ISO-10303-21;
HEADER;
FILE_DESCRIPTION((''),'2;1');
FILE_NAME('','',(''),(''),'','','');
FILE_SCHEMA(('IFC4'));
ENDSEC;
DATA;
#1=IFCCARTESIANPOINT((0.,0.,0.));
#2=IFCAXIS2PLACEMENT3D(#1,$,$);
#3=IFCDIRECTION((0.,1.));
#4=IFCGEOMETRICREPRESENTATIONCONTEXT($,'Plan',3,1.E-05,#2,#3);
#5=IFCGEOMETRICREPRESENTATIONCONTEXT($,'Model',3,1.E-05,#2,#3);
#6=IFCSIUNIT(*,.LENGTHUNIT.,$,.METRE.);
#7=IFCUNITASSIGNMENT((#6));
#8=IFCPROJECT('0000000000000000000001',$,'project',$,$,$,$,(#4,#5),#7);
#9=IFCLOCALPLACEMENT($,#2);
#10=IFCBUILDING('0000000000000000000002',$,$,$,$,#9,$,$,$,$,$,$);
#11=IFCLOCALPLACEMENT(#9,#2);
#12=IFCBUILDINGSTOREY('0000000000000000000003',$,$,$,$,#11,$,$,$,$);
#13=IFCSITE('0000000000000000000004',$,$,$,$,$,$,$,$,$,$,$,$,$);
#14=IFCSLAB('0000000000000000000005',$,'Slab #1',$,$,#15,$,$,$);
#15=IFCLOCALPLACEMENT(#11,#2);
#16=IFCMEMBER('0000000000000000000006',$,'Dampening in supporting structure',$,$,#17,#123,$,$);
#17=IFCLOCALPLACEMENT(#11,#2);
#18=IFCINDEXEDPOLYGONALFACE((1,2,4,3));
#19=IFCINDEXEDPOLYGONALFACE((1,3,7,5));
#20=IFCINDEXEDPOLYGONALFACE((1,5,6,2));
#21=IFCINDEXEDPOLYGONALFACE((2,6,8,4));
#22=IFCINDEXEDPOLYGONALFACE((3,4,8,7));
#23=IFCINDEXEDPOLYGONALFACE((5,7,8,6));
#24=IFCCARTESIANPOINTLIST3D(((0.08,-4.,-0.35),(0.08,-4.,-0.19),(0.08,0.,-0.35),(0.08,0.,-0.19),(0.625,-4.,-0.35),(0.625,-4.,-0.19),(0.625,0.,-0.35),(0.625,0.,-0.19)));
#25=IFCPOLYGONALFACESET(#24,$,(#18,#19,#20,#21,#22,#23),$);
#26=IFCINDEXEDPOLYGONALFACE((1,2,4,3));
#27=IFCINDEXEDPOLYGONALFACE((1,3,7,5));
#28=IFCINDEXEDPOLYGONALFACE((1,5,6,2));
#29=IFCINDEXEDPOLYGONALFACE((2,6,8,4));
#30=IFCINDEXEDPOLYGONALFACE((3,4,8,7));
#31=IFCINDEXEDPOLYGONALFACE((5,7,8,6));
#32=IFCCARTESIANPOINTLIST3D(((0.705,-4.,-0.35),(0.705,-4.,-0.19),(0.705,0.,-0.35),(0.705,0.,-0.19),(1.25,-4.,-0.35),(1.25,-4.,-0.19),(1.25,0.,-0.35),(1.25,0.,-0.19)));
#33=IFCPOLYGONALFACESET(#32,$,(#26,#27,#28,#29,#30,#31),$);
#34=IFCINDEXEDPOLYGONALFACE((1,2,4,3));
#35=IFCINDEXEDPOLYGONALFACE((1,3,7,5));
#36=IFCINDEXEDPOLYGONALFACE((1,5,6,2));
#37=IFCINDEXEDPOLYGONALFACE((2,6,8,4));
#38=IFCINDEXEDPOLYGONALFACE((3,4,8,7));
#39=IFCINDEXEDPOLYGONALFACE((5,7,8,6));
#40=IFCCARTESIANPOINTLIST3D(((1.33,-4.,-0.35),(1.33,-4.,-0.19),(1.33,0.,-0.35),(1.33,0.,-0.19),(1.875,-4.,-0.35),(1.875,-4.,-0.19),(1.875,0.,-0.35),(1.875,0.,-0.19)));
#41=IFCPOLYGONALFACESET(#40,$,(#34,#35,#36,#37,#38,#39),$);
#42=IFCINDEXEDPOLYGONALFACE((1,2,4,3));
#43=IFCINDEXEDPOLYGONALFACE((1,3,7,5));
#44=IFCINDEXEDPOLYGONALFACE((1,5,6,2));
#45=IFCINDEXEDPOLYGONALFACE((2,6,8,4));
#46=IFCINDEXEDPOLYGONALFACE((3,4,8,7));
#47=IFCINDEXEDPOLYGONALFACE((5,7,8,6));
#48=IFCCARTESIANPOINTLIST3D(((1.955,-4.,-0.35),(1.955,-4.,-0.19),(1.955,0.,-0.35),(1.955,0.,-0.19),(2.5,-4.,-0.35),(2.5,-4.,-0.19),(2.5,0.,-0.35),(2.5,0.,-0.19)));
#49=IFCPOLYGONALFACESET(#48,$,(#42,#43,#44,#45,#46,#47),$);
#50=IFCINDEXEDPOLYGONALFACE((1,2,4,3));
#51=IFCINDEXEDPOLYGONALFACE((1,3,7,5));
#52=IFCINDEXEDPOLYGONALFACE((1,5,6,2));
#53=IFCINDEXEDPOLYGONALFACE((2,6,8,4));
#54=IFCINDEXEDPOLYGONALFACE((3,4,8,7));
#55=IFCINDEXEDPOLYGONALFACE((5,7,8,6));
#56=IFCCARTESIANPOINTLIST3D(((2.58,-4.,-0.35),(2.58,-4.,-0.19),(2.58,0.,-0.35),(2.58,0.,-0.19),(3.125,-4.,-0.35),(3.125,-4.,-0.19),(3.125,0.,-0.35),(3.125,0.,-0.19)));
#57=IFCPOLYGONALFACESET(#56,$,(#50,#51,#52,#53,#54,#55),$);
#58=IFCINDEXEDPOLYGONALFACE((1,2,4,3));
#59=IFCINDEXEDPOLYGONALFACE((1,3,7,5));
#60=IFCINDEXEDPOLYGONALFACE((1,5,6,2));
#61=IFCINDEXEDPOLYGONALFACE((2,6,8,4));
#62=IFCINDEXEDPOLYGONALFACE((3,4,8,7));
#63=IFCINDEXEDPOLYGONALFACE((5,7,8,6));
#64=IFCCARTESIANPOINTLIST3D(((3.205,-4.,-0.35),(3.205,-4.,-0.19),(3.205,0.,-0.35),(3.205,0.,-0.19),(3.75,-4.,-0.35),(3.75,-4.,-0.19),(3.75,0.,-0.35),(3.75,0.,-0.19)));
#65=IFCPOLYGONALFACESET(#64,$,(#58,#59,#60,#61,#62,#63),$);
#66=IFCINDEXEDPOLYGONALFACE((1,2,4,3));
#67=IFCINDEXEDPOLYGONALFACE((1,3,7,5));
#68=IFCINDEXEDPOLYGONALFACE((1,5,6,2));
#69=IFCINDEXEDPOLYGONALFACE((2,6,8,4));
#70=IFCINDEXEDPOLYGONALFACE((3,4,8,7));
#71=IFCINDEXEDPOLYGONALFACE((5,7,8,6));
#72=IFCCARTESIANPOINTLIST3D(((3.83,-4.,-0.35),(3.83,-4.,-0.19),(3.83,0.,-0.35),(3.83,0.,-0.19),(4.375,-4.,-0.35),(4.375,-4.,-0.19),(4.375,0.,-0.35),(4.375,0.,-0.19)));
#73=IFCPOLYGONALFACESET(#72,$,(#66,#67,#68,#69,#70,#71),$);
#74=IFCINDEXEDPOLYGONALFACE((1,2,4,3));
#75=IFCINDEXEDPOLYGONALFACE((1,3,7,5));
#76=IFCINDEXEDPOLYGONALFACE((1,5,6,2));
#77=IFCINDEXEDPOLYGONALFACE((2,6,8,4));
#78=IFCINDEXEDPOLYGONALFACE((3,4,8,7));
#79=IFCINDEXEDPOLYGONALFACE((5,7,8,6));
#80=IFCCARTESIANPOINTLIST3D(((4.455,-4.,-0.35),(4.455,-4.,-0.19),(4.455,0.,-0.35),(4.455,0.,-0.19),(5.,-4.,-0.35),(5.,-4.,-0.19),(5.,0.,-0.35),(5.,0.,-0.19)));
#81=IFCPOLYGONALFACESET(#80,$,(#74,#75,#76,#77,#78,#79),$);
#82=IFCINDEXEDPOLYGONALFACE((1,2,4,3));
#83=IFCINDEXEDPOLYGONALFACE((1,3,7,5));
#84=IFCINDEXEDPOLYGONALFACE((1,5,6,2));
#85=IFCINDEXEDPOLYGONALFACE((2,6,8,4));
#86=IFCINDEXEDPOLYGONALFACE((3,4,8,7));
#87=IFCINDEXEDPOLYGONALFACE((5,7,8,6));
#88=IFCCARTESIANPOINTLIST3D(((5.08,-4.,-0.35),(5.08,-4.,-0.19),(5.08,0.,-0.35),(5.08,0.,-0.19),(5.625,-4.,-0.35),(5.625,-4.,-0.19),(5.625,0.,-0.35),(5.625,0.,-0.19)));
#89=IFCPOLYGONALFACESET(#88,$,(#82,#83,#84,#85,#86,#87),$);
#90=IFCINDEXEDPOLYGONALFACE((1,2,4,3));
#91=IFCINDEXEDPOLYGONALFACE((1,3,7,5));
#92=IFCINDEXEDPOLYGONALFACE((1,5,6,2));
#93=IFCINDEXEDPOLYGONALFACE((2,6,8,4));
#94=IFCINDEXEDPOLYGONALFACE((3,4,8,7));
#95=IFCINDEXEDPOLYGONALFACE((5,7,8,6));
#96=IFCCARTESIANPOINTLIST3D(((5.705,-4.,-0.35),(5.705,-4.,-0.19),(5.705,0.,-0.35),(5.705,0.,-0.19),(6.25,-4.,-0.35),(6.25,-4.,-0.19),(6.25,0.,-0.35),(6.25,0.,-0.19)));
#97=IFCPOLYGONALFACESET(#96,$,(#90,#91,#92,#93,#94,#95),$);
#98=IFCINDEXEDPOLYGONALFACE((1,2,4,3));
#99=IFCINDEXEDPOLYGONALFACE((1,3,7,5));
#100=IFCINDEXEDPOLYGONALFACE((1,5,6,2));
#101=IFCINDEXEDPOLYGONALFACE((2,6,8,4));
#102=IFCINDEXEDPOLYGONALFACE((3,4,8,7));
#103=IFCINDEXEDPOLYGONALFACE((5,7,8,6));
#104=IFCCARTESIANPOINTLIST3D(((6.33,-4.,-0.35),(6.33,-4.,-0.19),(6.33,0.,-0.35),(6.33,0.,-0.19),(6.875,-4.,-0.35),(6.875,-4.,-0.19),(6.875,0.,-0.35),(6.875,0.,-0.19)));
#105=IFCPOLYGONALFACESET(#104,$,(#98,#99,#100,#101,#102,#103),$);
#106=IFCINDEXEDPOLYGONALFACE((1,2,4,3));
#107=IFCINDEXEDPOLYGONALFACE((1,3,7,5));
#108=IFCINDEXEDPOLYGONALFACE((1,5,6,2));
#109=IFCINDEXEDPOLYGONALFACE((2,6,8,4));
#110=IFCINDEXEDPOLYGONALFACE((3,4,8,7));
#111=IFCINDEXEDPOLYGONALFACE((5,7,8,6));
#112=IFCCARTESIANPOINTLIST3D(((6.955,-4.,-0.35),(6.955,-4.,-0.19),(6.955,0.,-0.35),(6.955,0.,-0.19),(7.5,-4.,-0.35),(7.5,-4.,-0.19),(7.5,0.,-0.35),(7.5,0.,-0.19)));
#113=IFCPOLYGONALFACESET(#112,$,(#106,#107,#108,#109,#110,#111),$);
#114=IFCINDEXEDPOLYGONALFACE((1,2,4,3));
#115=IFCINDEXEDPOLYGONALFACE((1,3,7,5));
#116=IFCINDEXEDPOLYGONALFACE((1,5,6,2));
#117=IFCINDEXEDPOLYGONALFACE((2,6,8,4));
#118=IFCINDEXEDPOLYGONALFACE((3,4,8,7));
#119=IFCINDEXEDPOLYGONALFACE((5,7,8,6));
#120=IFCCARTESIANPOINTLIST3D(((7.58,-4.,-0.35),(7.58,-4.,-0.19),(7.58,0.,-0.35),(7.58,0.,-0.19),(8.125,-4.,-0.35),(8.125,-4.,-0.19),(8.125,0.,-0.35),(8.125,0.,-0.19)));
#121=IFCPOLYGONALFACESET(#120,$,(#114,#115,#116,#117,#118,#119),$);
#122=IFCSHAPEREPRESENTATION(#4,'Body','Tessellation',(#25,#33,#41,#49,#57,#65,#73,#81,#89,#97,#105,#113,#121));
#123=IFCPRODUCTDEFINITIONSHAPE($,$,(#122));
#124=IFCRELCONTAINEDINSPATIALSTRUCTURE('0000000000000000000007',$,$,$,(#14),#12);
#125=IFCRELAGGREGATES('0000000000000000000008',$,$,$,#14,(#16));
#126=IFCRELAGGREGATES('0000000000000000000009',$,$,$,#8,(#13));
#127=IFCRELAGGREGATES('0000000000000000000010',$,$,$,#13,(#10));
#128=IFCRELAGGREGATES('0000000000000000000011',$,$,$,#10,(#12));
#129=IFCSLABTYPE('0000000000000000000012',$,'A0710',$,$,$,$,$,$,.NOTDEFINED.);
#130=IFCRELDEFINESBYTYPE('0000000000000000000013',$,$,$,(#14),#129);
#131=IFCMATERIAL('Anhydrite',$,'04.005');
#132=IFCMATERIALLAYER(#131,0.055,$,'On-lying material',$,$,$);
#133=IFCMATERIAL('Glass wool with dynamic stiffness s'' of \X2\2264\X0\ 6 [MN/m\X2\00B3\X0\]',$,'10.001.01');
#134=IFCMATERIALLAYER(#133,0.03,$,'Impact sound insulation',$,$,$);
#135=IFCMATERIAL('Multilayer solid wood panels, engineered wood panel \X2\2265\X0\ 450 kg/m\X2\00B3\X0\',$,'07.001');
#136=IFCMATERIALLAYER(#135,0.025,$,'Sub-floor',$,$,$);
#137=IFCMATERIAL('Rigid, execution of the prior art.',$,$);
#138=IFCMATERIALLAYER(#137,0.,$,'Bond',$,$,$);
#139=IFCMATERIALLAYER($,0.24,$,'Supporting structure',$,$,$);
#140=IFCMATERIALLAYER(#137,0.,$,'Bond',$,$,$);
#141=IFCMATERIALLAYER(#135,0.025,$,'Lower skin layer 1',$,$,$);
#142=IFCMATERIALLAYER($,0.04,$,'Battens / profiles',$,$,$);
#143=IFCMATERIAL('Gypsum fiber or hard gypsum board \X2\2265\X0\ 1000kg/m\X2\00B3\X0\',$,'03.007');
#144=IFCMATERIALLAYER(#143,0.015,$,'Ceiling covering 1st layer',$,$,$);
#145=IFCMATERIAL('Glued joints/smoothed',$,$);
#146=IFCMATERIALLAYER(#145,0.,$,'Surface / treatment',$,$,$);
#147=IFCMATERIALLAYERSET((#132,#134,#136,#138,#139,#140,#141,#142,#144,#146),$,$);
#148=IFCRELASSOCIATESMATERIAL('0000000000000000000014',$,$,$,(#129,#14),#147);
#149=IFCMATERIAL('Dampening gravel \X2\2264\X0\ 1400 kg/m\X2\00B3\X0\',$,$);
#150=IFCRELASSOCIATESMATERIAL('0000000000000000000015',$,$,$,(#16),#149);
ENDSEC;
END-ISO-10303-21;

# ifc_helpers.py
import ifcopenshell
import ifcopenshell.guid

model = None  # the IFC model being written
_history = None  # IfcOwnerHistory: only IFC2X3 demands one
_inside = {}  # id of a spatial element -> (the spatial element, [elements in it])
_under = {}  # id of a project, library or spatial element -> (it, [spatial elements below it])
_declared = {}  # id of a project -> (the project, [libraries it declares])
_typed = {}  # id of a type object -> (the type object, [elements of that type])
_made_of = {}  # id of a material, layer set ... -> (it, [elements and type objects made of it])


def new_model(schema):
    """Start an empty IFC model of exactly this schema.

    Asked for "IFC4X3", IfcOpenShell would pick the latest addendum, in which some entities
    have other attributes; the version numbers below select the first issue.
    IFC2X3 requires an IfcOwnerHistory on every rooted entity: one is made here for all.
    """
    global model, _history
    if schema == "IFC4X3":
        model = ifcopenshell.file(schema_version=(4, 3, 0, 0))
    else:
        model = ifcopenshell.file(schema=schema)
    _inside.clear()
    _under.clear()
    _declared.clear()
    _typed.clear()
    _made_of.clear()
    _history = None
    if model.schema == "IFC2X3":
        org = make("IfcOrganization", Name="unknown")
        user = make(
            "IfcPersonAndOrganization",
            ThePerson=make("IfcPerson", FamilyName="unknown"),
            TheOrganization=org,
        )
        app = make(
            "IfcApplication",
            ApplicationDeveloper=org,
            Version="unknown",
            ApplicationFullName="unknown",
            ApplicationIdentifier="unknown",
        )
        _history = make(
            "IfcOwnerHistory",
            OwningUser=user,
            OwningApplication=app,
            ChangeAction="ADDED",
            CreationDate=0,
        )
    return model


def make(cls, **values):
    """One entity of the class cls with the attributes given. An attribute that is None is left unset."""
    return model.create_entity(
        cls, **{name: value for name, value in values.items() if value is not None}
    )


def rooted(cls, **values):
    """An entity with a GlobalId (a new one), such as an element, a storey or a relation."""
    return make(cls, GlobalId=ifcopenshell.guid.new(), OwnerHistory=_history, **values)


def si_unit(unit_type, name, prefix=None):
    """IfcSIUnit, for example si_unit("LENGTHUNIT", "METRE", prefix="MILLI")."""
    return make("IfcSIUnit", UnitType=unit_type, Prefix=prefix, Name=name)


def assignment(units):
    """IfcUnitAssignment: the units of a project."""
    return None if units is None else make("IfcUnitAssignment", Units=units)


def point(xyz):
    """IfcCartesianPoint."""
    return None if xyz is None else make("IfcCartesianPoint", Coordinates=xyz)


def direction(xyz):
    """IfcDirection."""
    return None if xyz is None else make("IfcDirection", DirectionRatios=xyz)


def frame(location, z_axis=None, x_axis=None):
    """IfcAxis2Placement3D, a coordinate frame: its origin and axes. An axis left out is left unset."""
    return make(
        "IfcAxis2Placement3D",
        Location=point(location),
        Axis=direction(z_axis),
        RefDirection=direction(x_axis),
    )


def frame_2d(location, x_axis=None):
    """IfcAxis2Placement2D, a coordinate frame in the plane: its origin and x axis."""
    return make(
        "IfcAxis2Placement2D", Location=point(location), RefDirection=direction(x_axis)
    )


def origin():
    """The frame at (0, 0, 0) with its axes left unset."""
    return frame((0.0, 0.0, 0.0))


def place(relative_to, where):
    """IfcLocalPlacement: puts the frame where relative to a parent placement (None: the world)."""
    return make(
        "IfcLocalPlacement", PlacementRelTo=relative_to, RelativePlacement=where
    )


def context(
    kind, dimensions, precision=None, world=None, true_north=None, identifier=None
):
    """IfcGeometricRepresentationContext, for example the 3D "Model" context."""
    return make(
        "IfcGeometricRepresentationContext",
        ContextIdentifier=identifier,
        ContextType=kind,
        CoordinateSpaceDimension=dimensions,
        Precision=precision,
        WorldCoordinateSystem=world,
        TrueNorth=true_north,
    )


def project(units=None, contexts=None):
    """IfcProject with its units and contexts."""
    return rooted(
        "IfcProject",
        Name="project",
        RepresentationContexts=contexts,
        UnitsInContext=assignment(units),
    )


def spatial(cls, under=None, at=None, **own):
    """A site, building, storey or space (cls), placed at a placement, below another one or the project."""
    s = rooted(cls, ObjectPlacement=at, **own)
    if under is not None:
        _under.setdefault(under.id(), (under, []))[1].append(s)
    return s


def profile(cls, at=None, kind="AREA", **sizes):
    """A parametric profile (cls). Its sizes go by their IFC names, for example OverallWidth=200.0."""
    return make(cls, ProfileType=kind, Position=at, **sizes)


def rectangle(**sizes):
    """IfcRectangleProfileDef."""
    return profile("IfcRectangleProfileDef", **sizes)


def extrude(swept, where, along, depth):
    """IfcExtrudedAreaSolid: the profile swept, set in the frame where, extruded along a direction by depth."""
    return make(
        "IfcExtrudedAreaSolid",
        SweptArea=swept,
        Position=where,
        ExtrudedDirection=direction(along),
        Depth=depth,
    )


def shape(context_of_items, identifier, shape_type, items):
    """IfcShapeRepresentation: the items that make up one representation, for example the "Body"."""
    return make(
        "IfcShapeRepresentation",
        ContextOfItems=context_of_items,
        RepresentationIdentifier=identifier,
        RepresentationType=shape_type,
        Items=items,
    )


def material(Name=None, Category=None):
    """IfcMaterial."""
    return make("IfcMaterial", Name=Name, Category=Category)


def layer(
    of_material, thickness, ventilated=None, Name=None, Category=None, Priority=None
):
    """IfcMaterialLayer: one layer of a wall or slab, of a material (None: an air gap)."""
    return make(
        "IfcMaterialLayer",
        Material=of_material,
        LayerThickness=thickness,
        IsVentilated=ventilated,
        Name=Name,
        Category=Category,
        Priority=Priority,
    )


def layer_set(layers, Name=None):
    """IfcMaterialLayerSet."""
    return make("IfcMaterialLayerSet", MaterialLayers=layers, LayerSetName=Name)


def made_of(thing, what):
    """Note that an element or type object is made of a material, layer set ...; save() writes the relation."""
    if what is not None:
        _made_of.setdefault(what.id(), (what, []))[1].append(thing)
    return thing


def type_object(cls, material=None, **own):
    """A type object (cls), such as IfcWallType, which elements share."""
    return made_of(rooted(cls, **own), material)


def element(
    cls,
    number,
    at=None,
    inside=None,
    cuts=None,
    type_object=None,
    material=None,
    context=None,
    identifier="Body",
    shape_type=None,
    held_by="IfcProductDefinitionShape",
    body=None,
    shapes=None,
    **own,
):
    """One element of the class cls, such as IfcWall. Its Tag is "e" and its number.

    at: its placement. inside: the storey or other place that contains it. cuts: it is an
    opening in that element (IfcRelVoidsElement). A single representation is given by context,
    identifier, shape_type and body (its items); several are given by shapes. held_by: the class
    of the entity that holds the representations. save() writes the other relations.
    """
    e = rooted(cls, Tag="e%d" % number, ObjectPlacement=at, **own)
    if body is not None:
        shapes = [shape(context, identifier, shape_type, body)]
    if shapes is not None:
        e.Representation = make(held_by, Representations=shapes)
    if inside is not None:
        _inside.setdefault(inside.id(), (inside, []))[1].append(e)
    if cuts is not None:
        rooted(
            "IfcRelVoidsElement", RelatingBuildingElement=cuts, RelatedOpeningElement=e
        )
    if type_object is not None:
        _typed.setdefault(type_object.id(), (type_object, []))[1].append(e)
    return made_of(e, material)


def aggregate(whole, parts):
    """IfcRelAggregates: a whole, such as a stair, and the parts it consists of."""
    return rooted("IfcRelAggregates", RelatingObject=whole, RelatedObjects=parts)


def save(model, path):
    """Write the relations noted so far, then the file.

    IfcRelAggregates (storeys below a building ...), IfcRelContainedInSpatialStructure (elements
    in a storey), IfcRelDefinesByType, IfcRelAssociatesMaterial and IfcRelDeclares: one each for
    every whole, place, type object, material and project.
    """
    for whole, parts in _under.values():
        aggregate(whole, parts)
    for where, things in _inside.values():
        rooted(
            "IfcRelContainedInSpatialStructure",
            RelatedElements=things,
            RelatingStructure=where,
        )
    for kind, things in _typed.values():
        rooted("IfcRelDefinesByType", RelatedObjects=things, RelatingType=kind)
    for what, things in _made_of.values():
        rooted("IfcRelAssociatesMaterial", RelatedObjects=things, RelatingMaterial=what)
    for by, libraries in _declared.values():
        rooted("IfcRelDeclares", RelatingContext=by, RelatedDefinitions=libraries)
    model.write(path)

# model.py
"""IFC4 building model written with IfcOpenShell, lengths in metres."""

from ifc_helpers import new_model, si_unit, direction, frame, frame_2d, origin, place, context, project, spatial, rectangle, extrude, material, layer, layer_set, type_object, element, aggregate, save


model = new_model("IFC4")

# Units and contexts
plan_context = context("Plan", 3, precision=1e-05, world=origin(), true_north=direction((0.0, 1.0)))
model_context = context("Model", 3, precision=1e-05, world=origin(), true_north=direction((0.0, 1.0)))
ifc_project = project(units=[si_unit("LENGTHUNIT", "METRE")], contexts=[plan_context, model_context])

# Site, building, storey
site = spatial("IfcSite", under=ifc_project)
building_placement = place(None, origin())
building = spatial("IfcBuilding", under=site, at=building_placement)
storey_placement = place(building_placement, origin())
storey = spatial("IfcBuildingStorey", under=building, at=storey_placement)

# Slab, member
ifc_material_1 = material(Name="Anhydrite", Category="04.005")
ifc_layer_1 = layer(ifc_material_1, 0.055, Name="On-lying material")
ifc_material_2 = material(Name="Glass wool with dynamic stiffness s' of ≤ 6 [MN/m³]", Category="10.001.01")
ifc_layer_2 = layer(ifc_material_2, 0.03, Name="Impact sound insulation")
ifc_material_3 = material(Name="Multilayer solid wood panels, engineered wood panel ≥ 450 kg/m³", Category="07.001")
ifc_layer_3 = layer(ifc_material_3, 0.025, Name="Sub-floor")
ifc_material_4 = material(Name="Rigid, execution of the prior art.")
ifc_layer_4 = layer(ifc_material_4, 0.0, Name="Bond")
ifc_layer_5 = layer(None, 0.24, Name="Supporting structure")
ifc_layer_6 = layer(ifc_material_4, 0.0, Name="Bond")
ifc_layer_7 = layer(ifc_material_3, 0.025, Name="Lower skin layer 1")
ifc_layer_8 = layer(None, 0.04, Name="Battens / profiles")
ifc_material_5 = material(Name="Gypsum fiber or hard gypsum board ≥ 1000kg/m³", Category="03.007")
ifc_layer_9 = layer(ifc_material_5, 0.015, Name="Ceiling covering 1st layer")
ifc_material_6 = material(Name="Glued joints/smoothed")
ifc_layer_10 = layer(ifc_material_6, 0.0, Name="Surface / treatment")
ifc_layer_set = layer_set([ifc_layer_1, ifc_layer_2, ifc_layer_3, ifc_layer_4, ifc_layer_5, ifc_layer_6, ifc_layer_7, ifc_layer_8, ifc_layer_9, ifc_layer_10])
slab_type = type_object("IfcSlabType", Name="A0710", PredefinedType="NOTDEFINED", material=ifc_layer_set)
slab_placement = place(None, frame((0.0, 0.0, 0.0), z_axis=(0.0, 0.0, -1.0), x_axis=(1.0, 0.0, 0.0)))
slab = element("IfcSlab", 1, at=slab_placement, inside=storey, type_object=slab_type, material=ifc_layer_set, Name="Slab #1")
ifc_material_7 = material(Name="Dampening gravel ≤ 1400 kg/m³")
member_1_placement = place(slab_placement, origin())
member_1 = element("IfcMember", 2, at=member_1_placement, material=ifc_material_7, Name="Dampening in supporting structure", context=plan_context, shape_type="SweptSolid", body=[
    extrude(rectangle(XDim=0.545, YDim=0.16, at=frame_2d((0.2725, 0.08), x_axis=(1.0, 0.0))), frame((0.08, 4.0, 0.19), z_axis=(0.0, -1.0, 0.0), x_axis=(1.0, 0.0, 0.0)), (0.0, 0.0, 1.0), 4.0),
    extrude(rectangle(XDim=0.545, YDim=0.16, at=frame_2d((0.2725, 0.08), x_axis=(1.0, 0.0))), frame((0.705, 4.0, 0.19), z_axis=(0.0, -1.0, 0.0), x_axis=(1.0, 0.0, 0.0)), (0.0, 0.0, 1.0), 4.0),
    extrude(rectangle(XDim=0.545, YDim=0.16, at=frame_2d((0.2725, 0.08), x_axis=(1.0, 0.0))), frame((1.33, 4.0, 0.19), z_axis=(0.0, -1.0, 0.0), x_axis=(1.0, 0.0, 0.0)), (0.0, 0.0, 1.0), 4.0),
    extrude(rectangle(XDim=0.545, YDim=0.16, at=frame_2d((0.2725, 0.08), x_axis=(1.0, 0.0))), frame((1.955, 4.0, 0.19), z_axis=(0.0, -1.0, 0.0), x_axis=(1.0, 0.0, 0.0)), (0.0, 0.0, 1.0), 4.0),
    extrude(rectangle(XDim=0.545, YDim=0.16, at=frame_2d((0.2725, 0.08), x_axis=(1.0, 0.0))), frame((2.58, 4.0, 0.19), z_axis=(0.0, -1.0, 0.0), x_axis=(1.0, 0.0, 0.0)), (0.0, 0.0, 1.0), 4.0),
    extrude(rectangle(XDim=0.545, YDim=0.16, at=frame_2d((0.2725, 0.08), x_axis=(1.0, 0.0))), frame((3.205, 4.0, 0.19), z_axis=(0.0, -1.0, 0.0), x_axis=(1.0, 0.0, 0.0)), (0.0, 0.0, 1.0), 4.0),
    extrude(rectangle(XDim=0.545, YDim=0.16, at=frame_2d((0.2725, 0.08), x_axis=(1.0, 0.0))), frame((3.83, 4.0, 0.19), z_axis=(0.0, -1.0, 0.0), x_axis=(1.0, 0.0, 0.0)), (0.0, 0.0, 1.0), 4.0),
    extrude(rectangle(XDim=0.545, YDim=0.16, at=frame_2d((0.2725, 0.08), x_axis=(1.0, 0.0))), frame((4.455, 4.0, 0.19), z_axis=(0.0, -1.0, 0.0), x_axis=(1.0, 0.0, 0.0)), (0.0, 0.0, 1.0), 4.0),
    extrude(rectangle(XDim=0.545, YDim=0.16, at=frame_2d((0.2725, 0.08), x_axis=(1.0, 0.0))), frame((5.08, 4.0, 0.19), z_axis=(0.0, -1.0, 0.0), x_axis=(1.0, 0.0, 0.0)), (0.0, 0.0, 1.0), 4.0),
    extrude(rectangle(XDim=0.545, YDim=0.16, at=frame_2d((0.2725, 0.08), x_axis=(1.0, 0.0))), frame((5.705, 4.0, 0.19), z_axis=(0.0, -1.0, 0.0), x_axis=(1.0, 0.0, 0.0)), (0.0, 0.0, 1.0), 4.0),
    extrude(rectangle(XDim=0.545, YDim=0.16, at=frame_2d((0.2725, 0.08), x_axis=(1.0, 0.0))), frame((6.33, 4.0, 0.19), z_axis=(0.0, -1.0, 0.0), x_axis=(1.0, 0.0, 0.0)), (0.0, 0.0, 1.0), 4.0),
    extrude(rectangle(XDim=0.545, YDim=0.16, at=frame_2d((0.2725, 0.08), x_axis=(1.0, 0.0))), frame((6.955, 4.0, 0.19), z_axis=(0.0, -1.0, 0.0), x_axis=(1.0, 0.0, 0.0)), (0.0, 0.0, 1.0), 4.0),
    extrude(rectangle(XDim=0.545, YDim=0.16, at=frame_2d((0.2725, 0.08), x_axis=(1.0, 0.0))), frame((7.58, 4.0, 0.19), z_axis=(0.0, -1.0, 0.0), x_axis=(1.0, 0.0, 0.0)), (0.0, 0.0, 1.0), 4.0),
])
aggregate(slab, [member_1])

save(model, "model.ifc")
